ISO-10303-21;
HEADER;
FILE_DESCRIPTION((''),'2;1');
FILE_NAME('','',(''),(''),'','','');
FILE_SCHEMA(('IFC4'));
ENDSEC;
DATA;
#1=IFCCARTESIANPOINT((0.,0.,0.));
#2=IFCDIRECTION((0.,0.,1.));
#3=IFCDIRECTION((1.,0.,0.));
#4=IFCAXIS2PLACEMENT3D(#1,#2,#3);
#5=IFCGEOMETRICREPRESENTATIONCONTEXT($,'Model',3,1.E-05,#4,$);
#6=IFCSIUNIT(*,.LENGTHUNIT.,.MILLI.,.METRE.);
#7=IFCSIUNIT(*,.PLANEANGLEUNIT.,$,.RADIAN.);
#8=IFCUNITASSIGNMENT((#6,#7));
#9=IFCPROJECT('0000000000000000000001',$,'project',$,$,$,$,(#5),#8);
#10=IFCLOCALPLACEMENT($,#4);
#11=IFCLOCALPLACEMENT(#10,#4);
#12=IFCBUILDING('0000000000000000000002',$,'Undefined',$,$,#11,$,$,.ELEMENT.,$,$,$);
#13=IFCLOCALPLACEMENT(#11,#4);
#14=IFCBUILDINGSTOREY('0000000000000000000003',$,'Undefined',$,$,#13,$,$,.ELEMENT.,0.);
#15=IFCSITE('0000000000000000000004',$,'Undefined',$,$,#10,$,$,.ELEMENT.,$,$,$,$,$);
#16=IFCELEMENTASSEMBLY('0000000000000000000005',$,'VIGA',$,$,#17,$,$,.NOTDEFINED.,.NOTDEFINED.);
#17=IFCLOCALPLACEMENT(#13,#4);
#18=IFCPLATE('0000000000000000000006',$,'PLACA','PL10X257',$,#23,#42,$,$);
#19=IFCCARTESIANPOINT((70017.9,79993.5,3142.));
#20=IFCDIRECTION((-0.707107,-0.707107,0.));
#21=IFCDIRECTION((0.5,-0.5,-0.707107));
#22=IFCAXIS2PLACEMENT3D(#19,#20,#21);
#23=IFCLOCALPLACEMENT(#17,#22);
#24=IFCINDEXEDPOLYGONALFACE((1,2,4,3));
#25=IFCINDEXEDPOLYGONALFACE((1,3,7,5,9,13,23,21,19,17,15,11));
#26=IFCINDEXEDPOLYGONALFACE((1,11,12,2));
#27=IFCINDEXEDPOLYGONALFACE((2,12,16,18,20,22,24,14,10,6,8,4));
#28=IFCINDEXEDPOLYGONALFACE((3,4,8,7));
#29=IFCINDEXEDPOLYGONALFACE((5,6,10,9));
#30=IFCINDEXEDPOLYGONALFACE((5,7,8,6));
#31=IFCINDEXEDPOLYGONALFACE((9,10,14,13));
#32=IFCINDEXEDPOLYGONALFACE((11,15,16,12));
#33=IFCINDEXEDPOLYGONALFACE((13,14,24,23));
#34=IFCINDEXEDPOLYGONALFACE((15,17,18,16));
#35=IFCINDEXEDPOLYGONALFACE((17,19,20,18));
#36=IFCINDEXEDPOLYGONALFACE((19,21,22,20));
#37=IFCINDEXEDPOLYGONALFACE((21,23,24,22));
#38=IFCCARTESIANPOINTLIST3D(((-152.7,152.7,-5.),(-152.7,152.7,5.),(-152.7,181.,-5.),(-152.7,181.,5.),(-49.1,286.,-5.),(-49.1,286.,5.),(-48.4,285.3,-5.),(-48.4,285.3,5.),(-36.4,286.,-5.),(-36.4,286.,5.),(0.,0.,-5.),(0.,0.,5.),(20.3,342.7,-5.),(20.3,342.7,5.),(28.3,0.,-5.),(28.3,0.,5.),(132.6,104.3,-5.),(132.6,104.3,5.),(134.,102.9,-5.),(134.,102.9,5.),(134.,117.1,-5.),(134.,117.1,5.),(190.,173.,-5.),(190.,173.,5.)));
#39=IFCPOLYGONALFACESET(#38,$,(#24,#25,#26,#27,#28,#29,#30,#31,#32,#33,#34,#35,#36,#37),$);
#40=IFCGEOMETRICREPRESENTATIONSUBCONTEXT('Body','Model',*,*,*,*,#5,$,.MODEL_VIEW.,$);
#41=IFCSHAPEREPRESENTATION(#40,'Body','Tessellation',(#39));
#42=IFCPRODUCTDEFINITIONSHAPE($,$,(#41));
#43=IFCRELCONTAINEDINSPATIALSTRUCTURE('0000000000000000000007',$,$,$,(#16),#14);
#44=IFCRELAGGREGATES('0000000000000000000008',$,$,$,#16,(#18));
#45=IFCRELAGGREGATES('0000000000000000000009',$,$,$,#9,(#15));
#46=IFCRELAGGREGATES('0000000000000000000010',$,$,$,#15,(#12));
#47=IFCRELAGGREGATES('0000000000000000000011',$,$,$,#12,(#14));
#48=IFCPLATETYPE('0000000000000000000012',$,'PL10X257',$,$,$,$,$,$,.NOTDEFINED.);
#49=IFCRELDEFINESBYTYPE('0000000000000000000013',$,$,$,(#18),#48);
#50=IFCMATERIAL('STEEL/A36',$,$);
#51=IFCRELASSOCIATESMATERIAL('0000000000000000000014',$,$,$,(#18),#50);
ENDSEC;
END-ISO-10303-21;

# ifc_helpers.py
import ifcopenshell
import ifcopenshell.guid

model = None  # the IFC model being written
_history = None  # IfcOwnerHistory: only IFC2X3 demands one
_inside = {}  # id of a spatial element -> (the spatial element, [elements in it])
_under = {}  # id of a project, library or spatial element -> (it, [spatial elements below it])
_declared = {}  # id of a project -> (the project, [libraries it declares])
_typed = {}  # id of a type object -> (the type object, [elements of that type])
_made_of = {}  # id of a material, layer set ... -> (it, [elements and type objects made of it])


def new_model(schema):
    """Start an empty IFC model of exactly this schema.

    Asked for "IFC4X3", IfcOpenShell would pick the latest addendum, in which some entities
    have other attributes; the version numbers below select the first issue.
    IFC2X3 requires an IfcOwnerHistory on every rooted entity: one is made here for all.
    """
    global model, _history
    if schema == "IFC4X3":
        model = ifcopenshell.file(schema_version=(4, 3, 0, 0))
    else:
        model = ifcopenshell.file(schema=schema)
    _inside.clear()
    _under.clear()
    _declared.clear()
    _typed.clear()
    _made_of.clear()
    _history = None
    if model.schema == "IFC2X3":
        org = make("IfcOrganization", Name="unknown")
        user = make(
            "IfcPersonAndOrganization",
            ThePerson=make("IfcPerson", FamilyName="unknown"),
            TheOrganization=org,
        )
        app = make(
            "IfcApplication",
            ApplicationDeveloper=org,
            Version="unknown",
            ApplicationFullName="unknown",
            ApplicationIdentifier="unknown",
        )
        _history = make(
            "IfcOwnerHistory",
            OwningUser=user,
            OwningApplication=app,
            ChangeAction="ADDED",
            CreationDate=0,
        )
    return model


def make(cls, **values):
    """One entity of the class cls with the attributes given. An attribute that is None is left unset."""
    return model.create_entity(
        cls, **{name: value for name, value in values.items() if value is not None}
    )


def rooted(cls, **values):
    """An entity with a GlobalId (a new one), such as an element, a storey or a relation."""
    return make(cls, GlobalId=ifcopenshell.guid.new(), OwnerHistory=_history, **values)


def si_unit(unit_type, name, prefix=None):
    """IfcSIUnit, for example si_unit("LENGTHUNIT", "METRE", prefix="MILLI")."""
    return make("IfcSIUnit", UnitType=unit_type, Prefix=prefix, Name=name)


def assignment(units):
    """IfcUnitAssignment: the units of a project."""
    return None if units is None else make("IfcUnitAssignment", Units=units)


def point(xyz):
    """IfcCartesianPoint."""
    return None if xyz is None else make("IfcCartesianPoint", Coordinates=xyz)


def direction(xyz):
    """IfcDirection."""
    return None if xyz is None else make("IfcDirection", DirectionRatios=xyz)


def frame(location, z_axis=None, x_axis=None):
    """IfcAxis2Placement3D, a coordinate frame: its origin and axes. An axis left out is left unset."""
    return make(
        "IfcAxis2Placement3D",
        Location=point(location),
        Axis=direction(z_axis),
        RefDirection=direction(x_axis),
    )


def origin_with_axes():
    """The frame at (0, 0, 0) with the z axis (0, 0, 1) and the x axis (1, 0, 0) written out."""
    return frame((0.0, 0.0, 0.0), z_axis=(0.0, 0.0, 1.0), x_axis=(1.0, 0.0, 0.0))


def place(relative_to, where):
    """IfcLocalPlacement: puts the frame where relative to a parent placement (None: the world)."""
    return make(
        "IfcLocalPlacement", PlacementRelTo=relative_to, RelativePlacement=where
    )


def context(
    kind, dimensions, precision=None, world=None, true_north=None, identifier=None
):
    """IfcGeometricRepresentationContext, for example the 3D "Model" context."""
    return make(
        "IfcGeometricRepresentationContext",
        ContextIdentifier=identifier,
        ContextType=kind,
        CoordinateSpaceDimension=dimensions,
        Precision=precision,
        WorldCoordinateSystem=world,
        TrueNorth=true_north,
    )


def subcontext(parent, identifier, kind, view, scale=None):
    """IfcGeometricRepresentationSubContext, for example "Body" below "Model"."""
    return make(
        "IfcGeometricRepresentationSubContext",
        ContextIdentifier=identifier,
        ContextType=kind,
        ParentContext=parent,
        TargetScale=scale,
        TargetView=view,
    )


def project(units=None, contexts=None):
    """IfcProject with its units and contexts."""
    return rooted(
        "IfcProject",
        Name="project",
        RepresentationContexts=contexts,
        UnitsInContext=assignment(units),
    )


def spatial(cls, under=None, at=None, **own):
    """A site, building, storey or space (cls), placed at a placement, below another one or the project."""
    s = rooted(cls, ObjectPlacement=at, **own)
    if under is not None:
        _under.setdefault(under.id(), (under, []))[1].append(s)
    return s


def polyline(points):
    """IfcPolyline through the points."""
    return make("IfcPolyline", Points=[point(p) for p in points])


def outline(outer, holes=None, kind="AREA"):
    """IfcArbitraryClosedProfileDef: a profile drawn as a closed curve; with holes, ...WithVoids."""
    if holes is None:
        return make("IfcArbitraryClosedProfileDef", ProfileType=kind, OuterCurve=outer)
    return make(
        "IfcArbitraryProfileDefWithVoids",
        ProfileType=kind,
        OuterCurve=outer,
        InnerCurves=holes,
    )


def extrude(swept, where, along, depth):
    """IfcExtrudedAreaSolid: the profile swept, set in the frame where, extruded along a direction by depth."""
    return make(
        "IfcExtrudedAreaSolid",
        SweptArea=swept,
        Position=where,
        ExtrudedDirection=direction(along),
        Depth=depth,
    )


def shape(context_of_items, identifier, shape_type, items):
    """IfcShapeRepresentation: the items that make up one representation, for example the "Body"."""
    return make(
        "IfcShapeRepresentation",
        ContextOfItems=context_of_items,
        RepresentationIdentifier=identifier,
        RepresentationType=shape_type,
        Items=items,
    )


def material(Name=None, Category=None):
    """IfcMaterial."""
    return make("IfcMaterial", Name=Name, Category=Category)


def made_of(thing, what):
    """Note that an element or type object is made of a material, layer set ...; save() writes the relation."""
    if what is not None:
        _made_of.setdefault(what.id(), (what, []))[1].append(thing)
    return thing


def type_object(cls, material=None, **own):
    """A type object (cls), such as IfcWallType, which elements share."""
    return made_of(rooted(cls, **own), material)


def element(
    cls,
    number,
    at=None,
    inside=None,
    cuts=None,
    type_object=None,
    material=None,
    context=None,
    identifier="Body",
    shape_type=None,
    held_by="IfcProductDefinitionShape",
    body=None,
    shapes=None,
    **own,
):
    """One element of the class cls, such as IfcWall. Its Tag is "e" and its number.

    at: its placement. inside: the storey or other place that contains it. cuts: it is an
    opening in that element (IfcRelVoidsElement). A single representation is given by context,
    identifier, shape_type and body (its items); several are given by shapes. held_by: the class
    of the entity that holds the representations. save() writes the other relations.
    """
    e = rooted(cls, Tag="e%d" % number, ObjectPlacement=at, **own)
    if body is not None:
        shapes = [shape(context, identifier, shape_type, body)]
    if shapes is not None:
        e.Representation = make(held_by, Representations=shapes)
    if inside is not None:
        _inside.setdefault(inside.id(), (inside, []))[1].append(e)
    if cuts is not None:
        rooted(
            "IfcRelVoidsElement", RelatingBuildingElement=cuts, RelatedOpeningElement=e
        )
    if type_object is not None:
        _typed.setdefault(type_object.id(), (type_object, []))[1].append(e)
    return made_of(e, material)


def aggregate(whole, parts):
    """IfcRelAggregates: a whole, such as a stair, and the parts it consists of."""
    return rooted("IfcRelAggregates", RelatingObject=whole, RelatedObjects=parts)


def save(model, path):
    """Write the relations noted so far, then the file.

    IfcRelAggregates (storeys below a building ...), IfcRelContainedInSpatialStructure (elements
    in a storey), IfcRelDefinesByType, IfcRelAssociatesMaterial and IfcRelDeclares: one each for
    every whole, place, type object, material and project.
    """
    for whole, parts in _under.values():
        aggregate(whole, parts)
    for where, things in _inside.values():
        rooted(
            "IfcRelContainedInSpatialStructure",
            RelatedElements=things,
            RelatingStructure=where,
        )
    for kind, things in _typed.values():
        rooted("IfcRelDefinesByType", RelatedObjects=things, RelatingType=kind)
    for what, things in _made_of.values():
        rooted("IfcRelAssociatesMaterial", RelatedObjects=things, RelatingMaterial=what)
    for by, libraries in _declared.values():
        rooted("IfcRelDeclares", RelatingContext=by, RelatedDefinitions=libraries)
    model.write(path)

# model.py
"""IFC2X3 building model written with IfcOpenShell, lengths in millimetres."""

from ifc_helpers import new_model, si_unit, frame, origin_with_axes, place, context, subcontext, project, spatial, polyline, outline, extrude, material, type_object, element, aggregate, save


model = new_model("IFC2X3")

# Units and contexts
model_context = context("Model", 3, precision=1e-05, world=origin_with_axes())
body_context = subcontext(model_context, "Body", "Model", "MODEL_VIEW")
ifc_project = project(units=[si_unit("LENGTHUNIT", "METRE", prefix="MILLI"), si_unit("PLANEANGLEUNIT", "RADIAN")], contexts=[model_context])

# Site, building, storey
site_placement = place(None, origin_with_axes())
site = spatial("IfcSite", under=ifc_project, at=site_placement, Name="Undefined", CompositionType="ELEMENT")
building_placement = place(site_placement, origin_with_axes())
building = spatial("IfcBuilding", under=site, at=building_placement, Name="Undefined", CompositionType="ELEMENT")
storey_placement = place(building_placement, origin_with_axes())
storey = spatial("IfcBuildingStorey", under=building, at=storey_placement, Name="Undefined", CompositionType="ELEMENT", Elevation=0.0)

# Element assembly
assembly_1_placement = place(storey_placement, origin_with_axes())
assembly_1 = element("IfcElementAssembly", 1, at=assembly_1_placement, inside=storey, Name="VIGA", AssemblyPlace="NOTDEFINED", PredefinedType="NOTDEFINED")
ifc_material_1 = material(Name="STEEL/A36")

# Plate
plate_type_1 = type_object("IfcPlateType", Name="PL10X257", PredefinedType="NOTDEFINED")
plate_1_placement = place(assembly_1_placement, frame((70017.9, 79993.5, 3142.0), z_axis=(-0.707107, -0.707107, 0.0), x_axis=(0.5, -0.5, -0.707107)))
plate_1 = element("IfcPlate", 2, at=plate_1_placement, type_object=plate_type_1, material=ifc_material_1, Name="PLACA", Description="PL10X257", context=body_context, shape_type="SweptSolid", body=[
    extrude(outline(polyline([(0.0, 0.0), (28.3, 0.0), (132.6, 104.3), (134.0, 102.9), (134.0, 117.1), (190.0, 173.0), (20.3, 342.7), (-36.4, 286.0), (-49.1, 286.0), (-48.4, 285.3), (-152.7, 181.0), (-152.7, 152.7), (0.0, 0.0)])), frame((0.0, 0.0, -5.0), z_axis=(0.0, 0.0, 1.0), x_axis=(1.0, 0.0, 0.0)), (0.0, 0.0, 1.0), 10.0),
])
aggregate(assembly_1, [plate_1])

save(model, "model.ifc")
